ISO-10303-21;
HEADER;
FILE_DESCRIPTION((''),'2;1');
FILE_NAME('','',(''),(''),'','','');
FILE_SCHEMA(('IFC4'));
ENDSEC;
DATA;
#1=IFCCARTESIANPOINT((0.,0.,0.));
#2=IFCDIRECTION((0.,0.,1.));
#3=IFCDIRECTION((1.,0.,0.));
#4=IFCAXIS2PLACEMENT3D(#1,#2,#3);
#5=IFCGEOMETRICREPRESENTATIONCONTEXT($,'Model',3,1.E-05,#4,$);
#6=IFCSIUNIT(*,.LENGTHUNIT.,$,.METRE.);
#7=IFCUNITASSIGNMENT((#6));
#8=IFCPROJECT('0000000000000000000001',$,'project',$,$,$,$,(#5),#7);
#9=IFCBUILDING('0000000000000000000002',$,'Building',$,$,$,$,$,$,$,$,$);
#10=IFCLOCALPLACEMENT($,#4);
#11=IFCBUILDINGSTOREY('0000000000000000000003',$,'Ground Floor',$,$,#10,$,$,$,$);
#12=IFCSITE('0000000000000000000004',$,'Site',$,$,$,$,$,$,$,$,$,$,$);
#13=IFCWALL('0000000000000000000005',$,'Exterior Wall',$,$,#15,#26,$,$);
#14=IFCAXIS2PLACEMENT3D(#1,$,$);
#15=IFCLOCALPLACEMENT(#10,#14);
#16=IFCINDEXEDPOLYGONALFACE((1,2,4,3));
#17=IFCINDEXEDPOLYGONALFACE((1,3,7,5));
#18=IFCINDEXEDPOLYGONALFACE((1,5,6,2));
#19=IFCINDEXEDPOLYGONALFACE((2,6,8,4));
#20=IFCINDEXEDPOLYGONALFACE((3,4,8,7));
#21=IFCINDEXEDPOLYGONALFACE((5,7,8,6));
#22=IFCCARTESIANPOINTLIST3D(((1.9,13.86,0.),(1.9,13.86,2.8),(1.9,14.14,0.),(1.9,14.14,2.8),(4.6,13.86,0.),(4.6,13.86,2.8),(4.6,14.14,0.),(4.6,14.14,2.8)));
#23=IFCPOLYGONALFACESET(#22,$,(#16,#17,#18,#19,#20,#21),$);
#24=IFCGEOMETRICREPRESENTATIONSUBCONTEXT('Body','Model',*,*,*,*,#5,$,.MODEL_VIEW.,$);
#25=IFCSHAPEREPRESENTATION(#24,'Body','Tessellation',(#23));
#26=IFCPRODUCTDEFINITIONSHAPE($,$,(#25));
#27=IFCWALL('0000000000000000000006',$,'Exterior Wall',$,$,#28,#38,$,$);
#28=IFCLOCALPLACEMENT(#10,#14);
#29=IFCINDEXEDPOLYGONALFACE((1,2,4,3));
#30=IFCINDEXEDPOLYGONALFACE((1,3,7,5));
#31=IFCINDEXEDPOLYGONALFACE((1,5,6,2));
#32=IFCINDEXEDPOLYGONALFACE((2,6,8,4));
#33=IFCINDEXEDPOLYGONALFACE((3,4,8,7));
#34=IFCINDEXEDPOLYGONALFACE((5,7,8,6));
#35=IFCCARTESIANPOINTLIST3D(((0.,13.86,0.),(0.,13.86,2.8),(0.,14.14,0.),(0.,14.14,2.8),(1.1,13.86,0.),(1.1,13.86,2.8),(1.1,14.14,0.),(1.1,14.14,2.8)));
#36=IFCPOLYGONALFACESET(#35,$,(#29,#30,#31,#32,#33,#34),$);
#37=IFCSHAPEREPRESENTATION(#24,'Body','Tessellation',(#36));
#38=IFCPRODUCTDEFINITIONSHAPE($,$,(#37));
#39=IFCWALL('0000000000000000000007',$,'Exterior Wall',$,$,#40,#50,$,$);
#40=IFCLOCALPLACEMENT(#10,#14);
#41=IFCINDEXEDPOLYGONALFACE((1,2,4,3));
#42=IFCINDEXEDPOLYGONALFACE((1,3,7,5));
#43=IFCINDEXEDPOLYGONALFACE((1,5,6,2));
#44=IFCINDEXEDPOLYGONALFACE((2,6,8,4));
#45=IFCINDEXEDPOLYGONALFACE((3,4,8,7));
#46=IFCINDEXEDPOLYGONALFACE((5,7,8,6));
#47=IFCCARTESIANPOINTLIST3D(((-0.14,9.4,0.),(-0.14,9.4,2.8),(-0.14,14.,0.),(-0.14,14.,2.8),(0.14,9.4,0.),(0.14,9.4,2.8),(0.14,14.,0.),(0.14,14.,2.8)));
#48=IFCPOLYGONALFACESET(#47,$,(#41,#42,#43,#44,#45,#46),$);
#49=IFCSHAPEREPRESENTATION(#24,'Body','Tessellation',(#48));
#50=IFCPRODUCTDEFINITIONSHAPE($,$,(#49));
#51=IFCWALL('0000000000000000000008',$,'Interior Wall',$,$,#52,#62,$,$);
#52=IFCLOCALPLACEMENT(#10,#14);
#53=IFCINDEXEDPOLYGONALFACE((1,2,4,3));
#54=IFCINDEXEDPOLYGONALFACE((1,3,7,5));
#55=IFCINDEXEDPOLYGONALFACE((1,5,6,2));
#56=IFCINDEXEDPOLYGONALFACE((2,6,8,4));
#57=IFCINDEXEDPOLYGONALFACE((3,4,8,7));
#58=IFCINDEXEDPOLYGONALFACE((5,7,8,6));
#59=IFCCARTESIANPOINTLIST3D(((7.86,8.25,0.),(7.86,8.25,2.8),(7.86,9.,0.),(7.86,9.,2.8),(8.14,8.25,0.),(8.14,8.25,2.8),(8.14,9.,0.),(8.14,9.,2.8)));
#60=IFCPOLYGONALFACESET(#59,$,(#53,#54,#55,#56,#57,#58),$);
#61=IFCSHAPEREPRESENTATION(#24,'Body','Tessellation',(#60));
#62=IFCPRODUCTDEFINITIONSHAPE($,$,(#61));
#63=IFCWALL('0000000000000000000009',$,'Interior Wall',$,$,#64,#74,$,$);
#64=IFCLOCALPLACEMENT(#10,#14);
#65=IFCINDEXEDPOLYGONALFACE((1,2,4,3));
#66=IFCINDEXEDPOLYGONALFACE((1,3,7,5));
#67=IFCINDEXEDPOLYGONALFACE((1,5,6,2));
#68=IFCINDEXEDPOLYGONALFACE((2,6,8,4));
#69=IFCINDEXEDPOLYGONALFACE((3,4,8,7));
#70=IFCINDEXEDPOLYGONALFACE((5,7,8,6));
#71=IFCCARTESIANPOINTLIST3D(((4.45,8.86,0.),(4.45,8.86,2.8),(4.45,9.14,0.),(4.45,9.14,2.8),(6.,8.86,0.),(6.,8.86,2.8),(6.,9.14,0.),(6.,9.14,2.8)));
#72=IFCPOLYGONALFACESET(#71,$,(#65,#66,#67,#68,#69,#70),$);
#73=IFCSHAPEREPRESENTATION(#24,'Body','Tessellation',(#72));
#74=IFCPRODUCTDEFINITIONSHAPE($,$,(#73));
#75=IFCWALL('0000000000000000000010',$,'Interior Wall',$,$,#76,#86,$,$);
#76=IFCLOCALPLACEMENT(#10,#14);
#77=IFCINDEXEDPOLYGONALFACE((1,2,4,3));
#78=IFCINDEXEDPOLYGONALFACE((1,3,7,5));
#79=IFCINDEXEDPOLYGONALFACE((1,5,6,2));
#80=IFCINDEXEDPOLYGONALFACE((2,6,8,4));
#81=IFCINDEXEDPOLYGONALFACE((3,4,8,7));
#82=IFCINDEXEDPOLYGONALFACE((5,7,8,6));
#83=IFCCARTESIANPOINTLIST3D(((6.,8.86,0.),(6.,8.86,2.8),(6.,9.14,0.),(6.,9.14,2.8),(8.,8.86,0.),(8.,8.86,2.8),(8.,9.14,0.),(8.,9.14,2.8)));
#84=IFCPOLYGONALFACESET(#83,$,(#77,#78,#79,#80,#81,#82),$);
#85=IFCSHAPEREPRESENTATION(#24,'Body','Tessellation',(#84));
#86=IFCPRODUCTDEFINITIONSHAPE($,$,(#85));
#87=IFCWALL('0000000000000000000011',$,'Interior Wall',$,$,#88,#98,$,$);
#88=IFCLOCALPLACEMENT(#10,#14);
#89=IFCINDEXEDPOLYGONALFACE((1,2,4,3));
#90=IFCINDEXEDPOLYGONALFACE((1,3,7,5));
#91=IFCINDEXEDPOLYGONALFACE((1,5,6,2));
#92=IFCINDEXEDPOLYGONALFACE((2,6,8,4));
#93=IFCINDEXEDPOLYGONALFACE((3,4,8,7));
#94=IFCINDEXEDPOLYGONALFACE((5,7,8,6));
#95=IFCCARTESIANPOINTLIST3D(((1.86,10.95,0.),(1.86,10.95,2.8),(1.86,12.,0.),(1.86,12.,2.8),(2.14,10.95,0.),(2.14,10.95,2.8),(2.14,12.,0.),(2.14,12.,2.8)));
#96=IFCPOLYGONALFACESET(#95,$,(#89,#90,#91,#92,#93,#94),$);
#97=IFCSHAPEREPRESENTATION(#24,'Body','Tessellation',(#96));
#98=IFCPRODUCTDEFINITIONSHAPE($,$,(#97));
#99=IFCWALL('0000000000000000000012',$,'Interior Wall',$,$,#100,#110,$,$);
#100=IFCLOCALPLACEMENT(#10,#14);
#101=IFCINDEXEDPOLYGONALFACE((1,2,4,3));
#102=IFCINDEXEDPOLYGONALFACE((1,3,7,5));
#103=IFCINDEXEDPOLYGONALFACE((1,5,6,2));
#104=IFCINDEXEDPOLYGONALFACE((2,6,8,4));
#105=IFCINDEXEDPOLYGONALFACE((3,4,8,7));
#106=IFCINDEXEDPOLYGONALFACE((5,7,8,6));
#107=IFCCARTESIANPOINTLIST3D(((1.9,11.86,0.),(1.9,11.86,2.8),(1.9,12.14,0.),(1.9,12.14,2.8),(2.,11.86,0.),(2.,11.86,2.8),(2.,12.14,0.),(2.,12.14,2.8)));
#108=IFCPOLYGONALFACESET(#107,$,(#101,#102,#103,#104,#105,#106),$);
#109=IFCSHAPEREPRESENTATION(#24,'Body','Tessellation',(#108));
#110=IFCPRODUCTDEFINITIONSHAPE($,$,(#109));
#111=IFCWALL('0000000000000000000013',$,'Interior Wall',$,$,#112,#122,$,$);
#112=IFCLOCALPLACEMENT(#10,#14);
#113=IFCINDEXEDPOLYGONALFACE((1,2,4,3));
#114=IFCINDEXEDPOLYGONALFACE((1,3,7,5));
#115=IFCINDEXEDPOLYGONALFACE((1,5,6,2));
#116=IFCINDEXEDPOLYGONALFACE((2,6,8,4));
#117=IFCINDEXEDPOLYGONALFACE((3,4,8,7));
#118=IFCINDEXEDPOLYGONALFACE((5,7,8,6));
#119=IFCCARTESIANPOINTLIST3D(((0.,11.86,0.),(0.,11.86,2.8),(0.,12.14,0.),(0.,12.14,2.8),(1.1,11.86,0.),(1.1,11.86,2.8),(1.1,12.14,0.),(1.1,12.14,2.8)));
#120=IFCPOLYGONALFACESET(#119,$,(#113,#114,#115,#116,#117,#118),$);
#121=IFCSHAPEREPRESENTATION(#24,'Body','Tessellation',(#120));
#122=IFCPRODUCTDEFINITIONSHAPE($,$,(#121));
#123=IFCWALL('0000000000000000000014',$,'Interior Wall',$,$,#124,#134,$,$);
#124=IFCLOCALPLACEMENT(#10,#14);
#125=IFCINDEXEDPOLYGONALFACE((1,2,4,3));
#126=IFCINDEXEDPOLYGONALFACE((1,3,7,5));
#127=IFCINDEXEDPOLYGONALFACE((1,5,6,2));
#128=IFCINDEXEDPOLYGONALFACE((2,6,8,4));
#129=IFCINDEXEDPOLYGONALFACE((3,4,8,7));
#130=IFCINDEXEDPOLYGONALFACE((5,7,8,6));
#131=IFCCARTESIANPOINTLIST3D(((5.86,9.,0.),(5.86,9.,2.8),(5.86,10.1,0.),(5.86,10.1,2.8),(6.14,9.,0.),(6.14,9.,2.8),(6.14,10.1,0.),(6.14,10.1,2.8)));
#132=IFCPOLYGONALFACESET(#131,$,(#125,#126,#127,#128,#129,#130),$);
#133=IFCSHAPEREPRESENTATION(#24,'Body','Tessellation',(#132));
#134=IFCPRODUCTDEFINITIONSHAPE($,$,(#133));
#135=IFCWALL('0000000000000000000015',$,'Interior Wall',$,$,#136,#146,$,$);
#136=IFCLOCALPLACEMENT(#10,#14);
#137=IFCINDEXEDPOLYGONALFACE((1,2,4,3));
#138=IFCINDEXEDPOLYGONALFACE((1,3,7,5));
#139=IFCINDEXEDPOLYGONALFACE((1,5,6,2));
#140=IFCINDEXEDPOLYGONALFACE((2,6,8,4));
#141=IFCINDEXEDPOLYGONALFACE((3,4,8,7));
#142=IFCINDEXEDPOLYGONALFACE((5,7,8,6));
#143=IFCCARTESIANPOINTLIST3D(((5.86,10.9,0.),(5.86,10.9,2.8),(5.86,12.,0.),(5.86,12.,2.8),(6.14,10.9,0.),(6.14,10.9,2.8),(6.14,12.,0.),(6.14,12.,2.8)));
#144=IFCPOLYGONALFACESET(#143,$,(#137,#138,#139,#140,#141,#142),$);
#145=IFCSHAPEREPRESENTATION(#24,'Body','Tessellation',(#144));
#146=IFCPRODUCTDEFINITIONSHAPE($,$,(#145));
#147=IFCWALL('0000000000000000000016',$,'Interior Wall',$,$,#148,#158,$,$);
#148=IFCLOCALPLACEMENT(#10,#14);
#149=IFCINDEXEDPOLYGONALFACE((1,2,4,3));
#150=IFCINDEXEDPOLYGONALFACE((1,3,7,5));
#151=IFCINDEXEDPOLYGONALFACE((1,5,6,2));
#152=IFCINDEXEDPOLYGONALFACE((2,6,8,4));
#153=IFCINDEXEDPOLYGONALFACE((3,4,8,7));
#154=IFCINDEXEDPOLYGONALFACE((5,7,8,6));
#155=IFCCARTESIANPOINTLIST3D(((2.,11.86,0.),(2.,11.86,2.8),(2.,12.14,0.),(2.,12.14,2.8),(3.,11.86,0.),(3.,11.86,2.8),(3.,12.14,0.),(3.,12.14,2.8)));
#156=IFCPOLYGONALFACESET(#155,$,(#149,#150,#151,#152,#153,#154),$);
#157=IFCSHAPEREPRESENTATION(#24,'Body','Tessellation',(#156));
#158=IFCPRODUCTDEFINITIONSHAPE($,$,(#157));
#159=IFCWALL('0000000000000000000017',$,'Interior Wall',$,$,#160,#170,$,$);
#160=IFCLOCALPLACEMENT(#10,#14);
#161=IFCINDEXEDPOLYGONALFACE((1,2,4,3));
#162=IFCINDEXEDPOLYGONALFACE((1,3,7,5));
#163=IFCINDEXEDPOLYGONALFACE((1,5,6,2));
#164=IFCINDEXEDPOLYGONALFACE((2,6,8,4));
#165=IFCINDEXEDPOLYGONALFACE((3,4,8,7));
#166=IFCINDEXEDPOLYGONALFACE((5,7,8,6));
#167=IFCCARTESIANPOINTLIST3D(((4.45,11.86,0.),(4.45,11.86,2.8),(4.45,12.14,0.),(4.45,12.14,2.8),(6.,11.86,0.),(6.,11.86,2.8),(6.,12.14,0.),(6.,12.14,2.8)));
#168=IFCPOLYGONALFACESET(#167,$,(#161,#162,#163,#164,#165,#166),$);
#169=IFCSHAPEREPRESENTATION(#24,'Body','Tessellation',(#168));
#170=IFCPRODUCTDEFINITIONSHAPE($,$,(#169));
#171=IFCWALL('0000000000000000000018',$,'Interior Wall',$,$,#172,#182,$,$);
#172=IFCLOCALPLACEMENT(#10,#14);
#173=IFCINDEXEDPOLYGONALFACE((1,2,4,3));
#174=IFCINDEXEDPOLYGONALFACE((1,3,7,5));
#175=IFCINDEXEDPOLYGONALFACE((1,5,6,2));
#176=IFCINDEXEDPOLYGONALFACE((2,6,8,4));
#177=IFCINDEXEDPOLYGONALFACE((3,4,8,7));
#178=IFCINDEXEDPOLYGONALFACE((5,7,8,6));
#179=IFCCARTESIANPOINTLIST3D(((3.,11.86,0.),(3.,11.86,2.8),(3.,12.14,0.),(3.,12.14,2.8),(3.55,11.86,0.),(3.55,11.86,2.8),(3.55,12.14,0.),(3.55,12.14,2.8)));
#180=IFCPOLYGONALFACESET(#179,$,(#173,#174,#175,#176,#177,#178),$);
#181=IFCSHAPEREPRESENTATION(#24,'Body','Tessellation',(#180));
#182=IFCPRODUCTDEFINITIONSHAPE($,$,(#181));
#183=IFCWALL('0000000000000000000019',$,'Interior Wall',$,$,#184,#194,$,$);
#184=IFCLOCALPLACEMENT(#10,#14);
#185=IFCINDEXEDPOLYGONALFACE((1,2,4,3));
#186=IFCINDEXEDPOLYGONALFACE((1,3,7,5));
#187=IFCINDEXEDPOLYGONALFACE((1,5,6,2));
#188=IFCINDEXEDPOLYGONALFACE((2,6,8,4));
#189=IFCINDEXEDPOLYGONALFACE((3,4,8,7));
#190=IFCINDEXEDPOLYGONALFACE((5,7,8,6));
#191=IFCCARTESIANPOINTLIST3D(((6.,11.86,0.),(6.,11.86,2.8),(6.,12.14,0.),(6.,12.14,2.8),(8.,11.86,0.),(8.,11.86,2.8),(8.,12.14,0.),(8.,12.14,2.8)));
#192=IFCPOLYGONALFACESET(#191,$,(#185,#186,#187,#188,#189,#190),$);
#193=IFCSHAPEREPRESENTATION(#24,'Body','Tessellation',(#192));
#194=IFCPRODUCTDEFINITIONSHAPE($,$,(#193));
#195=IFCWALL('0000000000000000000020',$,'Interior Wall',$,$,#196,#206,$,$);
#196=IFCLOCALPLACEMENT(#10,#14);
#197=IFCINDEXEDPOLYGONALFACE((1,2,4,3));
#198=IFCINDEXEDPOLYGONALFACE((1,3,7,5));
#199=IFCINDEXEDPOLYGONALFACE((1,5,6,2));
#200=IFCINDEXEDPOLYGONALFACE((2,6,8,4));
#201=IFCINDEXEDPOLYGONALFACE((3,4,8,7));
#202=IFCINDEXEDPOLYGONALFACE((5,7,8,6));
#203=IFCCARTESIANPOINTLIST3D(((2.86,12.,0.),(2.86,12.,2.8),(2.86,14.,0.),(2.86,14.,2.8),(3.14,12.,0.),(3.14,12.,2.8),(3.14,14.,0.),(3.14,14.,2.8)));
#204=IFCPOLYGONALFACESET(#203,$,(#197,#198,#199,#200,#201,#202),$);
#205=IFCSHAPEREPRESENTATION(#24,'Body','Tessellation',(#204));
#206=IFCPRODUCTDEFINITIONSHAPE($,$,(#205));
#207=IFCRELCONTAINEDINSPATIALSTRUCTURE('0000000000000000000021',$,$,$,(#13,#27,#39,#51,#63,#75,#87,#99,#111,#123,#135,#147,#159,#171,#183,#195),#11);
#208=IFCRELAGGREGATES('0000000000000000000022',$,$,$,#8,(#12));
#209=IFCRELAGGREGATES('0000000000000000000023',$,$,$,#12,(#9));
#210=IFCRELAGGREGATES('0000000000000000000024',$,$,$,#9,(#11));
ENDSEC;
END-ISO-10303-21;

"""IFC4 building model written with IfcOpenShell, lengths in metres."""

from ifc_helpers import new_model, si_unit, frame, origin_with_axes, place, context, subcontext, project, spatial, indexed_curve, outline, extrude, element, save


model = new_model("IFC4")

# Units and contexts
model_context = context("Model", 3, precision=1e-05, world=origin_with_axes())
body_context = subcontext(model_context, "Body", "Model", "MODEL_VIEW")
ifc_project = project(units=[si_unit("LENGTHUNIT", "METRE")], contexts=[model_context])

# Site, building, storey
site = spatial("IfcSite", under=ifc_project, Name="Site")
building = spatial("IfcBuilding", under=site, Name="Building")
storey_placement = place(None, origin_with_axes())
storey = spatial("IfcBuildingStorey", under=building, at=storey_placement, Name="Ground Floor")

# Walls
wall_1_placement = place(storey_placement, frame((4.6, 14.0, 0.0), z_axis=(0.0, 0.0, 1.0), x_axis=(-1.0, 0.0, 0.0)))
element("IfcWall", 1, at=wall_1_placement, inside=storey, Name="Exterior Wall", context=body_context, shape_type="SweptSolid", body=[
    extrude(outline(indexed_curve([(0.0, 0.0), (0.0, 0.28), (2.7, 0.28), (2.7, 0.0), (0.0, 0.0)], self_intersect=False)), frame((0.0, -0.14, 0.0), z_axis=(0.0, 0.0, 1.0), x_axis=(1.0, 0.0, 0.0)), (0.0, 0.0, 1.0), 2.8),
])
wall_2_placement = place(storey_placement, frame((1.1, 14.0, 0.0), z_axis=(0.0, 0.0, 1.0), x_axis=(-1.0, 0.0, 0.0)))
element("IfcWall", 2, at=wall_2_placement, inside=storey, Name="Exterior Wall", context=body_context, shape_type="SweptSolid", body=[
    extrude(outline(indexed_curve([(0.0, 0.0), (0.0, 0.28), (1.1, 0.28), (1.1, 0.0), (0.0, 0.0)], self_intersect=False)), frame((0.0, -0.14, 0.0), z_axis=(0.0, 0.0, 1.0), x_axis=(1.0, 0.0, 0.0)), (0.0, 0.0, 1.0), 2.8),
])
wall_3_placement = place(storey_placement, frame((0.0, 14.0, 0.0), z_axis=(0.0, 0.0, 1.0), x_axis=(0.0, -1.0, 0.0)))
element("IfcWall", 3, at=wall_3_placement, inside=storey, Name="Exterior Wall", context=body_context, shape_type="SweptSolid", body=[
    extrude(outline(indexed_curve([(0.0, 0.0), (0.0, 0.28), (4.6, 0.28), (4.6, 0.0), (0.0, 0.0)], self_intersect=False)), frame((0.0, -0.14, 0.0), z_axis=(0.0, 0.0, 1.0), x_axis=(1.0, 0.0, 0.0)), (0.0, 0.0, 1.0), 2.8),
])
wall_4_placement = place(storey_placement, frame((8.0, 9.0, 0.0), z_axis=(0.0, 0.0, 1.0), x_axis=(0.0, -1.0, 0.0)))
element("IfcWall", 4, at=wall_4_placement, inside=storey, Name="Interior Wall", context=body_context, shape_type="SweptSolid", body=[
    extrude(outline(indexed_curve([(0.0, 0.0), (0.0, 0.28), (0.75, 0.28), (0.75, 0.0), (0.0, 0.0)], self_intersect=False)), frame((0.0, -0.14, 0.0), z_axis=(0.0, 0.0, 1.0), x_axis=(1.0, 0.0, 0.0)), (0.0, 0.0, 1.0), 2.8),
])
wall_5_placement = place(storey_placement, frame((6.0, 9.0, 0.0), z_axis=(0.0, 0.0, 1.0), x_axis=(-1.0, 0.0, 0.0)))
element("IfcWall", 5, at=wall_5_placement, inside=storey, Name="Interior Wall", context=body_context, shape_type="SweptSolid", body=[
    extrude(outline(indexed_curve([(0.0, 0.0), (0.0, 0.28), (1.55, 0.28), (1.55, 0.0), (0.0, 0.0)], self_intersect=False)), frame((0.0, -0.14, 0.0), z_axis=(0.0, 0.0, 1.0), x_axis=(1.0, 0.0, 0.0)), (0.0, 0.0, 1.0), 2.8),
])
wall_6_placement = place(storey_placement, frame((8.0, 9.0, 0.0), z_axis=(0.0, 0.0, 1.0), x_axis=(-1.0, 0.0, 0.0)))
element("IfcWall", 6, at=wall_6_placement, inside=storey, Name="Interior Wall", context=body_context, shape_type="SweptSolid", body=[
    extrude(outline(indexed_curve([(0.0, 0.0), (0.0, 0.28), (2.0, 0.28), (2.0, 0.0), (0.0, 0.0)], self_intersect=False)), frame((0.0, -0.14, 0.0), z_axis=(0.0, 0.0, 1.0), x_axis=(1.0, 0.0, 0.0)), (0.0, 0.0, 1.0), 2.8),
])
wall_7_placement = place(storey_placement, frame((2.0, 10.95, 0.0), z_axis=(0.0, 0.0, 1.0), x_axis=(0.0, 1.0, 0.0)))
element("IfcWall", 7, at=wall_7_placement, inside=storey, Name="Interior Wall", context=body_context, shape_type="SweptSolid", body=[
    extrude(outline(indexed_curve([(0.0, 0.0), (0.0, 0.28), (1.05, 0.28), (1.05, 0.0), (0.0, 0.0)], self_intersect=False)), frame((0.0, -0.14, 0.0), z_axis=(0.0, 0.0, 1.0), x_axis=(1.0, 0.0, 0.0)), (0.0, 0.0, 1.0), 2.8),
])
wall_8_placement = place(storey_placement, frame((2.0, 12.0, 0.0), z_axis=(0.0, 0.0, 1.0), x_axis=(-1.0, 0.0, 0.0)))
element("IfcWall", 8, at=wall_8_placement, inside=storey, Name="Interior Wall", context=body_context, shape_type="SweptSolid", body=[
    extrude(outline(indexed_curve([(0.0, 0.0), (0.0, 0.28), (0.1, 0.28), (0.1, 0.0), (0.0, 0.0)], self_intersect=False)), frame((0.0, -0.14, 0.0), z_axis=(0.0, 0.0, 1.0), x_axis=(1.0, 0.0, 0.0)), (0.0, 0.0, 1.0), 2.8),
])
wall_9_placement = place(storey_placement, frame((1.1, 12.0, 0.0), z_axis=(0.0, 0.0, 1.0), x_axis=(-1.0, 0.0, 0.0)))
element("IfcWall", 9, at=wall_9_placement, inside=storey, Name="Interior Wall", context=body_context, shape_type="SweptSolid", body=[
    extrude(outline(indexed_curve([(0.0, 0.0), (0.0, 0.28), (1.1, 0.28), (1.1, 0.0), (0.0, 0.0)], self_intersect=False)), frame((0.0, -0.14, 0.0), z_axis=(0.0, 0.0, 1.0), x_axis=(1.0, 0.0, 0.0)), (0.0, 0.0, 1.0), 2.8),
])
for number, where, z_axis, x_axis, name in (
    (10, (6.0, 9.0, 0.0), (0.0, 0.0, 1.0), (0.0, 1.0, 0.0), "Interior Wall"),
    (11, (6.0, 10.9, 0.0), (0.0, 0.0, 1.0), (0.0, 1.0, 0.0), "Interior Wall"),
):
    element("IfcWall", number, at=place(storey_placement, frame(where, z_axis=z_axis, x_axis=x_axis)), inside=storey, Name=name, context=body_context, shape_type="SweptSolid", body=[
        extrude(outline(indexed_curve([(0.0, 0.0), (0.0, 0.28), (1.1, 0.28), (1.1, 0.0), (0.0, 0.0)], self_intersect=False)), frame((0.0, -0.14, 0.0), z_axis=(0.0, 0.0, 1.0), x_axis=(1.0, 0.0, 0.0)), (0.0, 0.0, 1.0), 2.8),
    ])
wall_10_placement = place(storey_placement, frame((3.0, 12.0, 0.0), z_axis=(0.0, 0.0, 1.0), x_axis=(-1.0, 0.0, 0.0)))
element("IfcWall", 12, at=wall_10_placement, inside=storey, Name="Interior Wall", context=body_context, shape_type="SweptSolid", body=[
    extrude(outline(indexed_curve([(0.0, 0.0), (0.0, 0.28), (1.0, 0.28), (1.0, 0.0), (0.0, 0.0)], self_intersect=False)), frame((0.0, -0.14, 0.0), z_axis=(0.0, 0.0, 1.0), x_axis=(1.0, 0.0, 0.0)), (0.0, 0.0, 1.0), 2.8),
])
wall_11_placement = place(storey_placement, frame((6.0, 12.0, 0.0), z_axis=(0.0, 0.0, 1.0), x_axis=(-1.0, 0.0, 0.0)))
element("IfcWall", 13, at=wall_11_placement, inside=storey, Name="Interior Wall", context=body_context, shape_type="SweptSolid", body=[
    extrude(outline(indexed_curve([(0.0, 0.0), (0.0, 0.28), (1.55, 0.28), (1.55, 0.0), (0.0, 0.0)], self_intersect=False)), frame((0.0, -0.14, 0.0), z_axis=(0.0, 0.0, 1.0), x_axis=(1.0, 0.0, 0.0)), (0.0, 0.0, 1.0), 2.8),
])
wall_12_placement = place(storey_placement, frame((3.55, 12.0, 0.0), z_axis=(0.0, 0.0, 1.0), x_axis=(-1.0, 0.0, 0.0)))
element("IfcWall", 14, at=wall_12_placement, inside=storey, Name="Interior Wall", context=body_context, shape_type="SweptSolid", body=[
    extrude(outline(indexed_curve([(0.0, 0.0), (0.0, 0.28), (0.55, 0.28), (0.55, 0.0), (0.0, 0.0)], self_intersect=False)), frame((0.0, -0.14, 0.0), z_axis=(0.0, 0.0, 1.0), x_axis=(1.0, 0.0, 0.0)), (0.0, 0.0, 1.0), 2.8),
])
for number, where, z_axis, x_axis, name in (
    (15, (8.0, 12.0, 0.0), (0.0, 0.0, 1.0), (-1.0, 0.0, 0.0), "Interior Wall"),
    (16, (3.0, 12.0, 0.0), (0.0, 0.0, 1.0), (0.0, 1.0, 0.0), "Interior Wall"),
):
    element("IfcWall", number, at=place(storey_placement, frame(where, z_axis=z_axis, x_axis=x_axis)), inside=storey, Name=name, context=body_context, shape_type="SweptSolid", body=[
        extrude(outline(indexed_curve([(0.0, 0.0), (0.0, 0.28), (2.0, 0.28), (2.0, 0.0), (0.0, 0.0)], self_intersect=False)), frame((0.0, -0.14, 0.0), z_axis=(0.0, 0.0, 1.0), x_axis=(1.0, 0.0, 0.0)), (0.0, 0.0, 1.0), 2.8),
    ])

save(model, "model.ifc")
